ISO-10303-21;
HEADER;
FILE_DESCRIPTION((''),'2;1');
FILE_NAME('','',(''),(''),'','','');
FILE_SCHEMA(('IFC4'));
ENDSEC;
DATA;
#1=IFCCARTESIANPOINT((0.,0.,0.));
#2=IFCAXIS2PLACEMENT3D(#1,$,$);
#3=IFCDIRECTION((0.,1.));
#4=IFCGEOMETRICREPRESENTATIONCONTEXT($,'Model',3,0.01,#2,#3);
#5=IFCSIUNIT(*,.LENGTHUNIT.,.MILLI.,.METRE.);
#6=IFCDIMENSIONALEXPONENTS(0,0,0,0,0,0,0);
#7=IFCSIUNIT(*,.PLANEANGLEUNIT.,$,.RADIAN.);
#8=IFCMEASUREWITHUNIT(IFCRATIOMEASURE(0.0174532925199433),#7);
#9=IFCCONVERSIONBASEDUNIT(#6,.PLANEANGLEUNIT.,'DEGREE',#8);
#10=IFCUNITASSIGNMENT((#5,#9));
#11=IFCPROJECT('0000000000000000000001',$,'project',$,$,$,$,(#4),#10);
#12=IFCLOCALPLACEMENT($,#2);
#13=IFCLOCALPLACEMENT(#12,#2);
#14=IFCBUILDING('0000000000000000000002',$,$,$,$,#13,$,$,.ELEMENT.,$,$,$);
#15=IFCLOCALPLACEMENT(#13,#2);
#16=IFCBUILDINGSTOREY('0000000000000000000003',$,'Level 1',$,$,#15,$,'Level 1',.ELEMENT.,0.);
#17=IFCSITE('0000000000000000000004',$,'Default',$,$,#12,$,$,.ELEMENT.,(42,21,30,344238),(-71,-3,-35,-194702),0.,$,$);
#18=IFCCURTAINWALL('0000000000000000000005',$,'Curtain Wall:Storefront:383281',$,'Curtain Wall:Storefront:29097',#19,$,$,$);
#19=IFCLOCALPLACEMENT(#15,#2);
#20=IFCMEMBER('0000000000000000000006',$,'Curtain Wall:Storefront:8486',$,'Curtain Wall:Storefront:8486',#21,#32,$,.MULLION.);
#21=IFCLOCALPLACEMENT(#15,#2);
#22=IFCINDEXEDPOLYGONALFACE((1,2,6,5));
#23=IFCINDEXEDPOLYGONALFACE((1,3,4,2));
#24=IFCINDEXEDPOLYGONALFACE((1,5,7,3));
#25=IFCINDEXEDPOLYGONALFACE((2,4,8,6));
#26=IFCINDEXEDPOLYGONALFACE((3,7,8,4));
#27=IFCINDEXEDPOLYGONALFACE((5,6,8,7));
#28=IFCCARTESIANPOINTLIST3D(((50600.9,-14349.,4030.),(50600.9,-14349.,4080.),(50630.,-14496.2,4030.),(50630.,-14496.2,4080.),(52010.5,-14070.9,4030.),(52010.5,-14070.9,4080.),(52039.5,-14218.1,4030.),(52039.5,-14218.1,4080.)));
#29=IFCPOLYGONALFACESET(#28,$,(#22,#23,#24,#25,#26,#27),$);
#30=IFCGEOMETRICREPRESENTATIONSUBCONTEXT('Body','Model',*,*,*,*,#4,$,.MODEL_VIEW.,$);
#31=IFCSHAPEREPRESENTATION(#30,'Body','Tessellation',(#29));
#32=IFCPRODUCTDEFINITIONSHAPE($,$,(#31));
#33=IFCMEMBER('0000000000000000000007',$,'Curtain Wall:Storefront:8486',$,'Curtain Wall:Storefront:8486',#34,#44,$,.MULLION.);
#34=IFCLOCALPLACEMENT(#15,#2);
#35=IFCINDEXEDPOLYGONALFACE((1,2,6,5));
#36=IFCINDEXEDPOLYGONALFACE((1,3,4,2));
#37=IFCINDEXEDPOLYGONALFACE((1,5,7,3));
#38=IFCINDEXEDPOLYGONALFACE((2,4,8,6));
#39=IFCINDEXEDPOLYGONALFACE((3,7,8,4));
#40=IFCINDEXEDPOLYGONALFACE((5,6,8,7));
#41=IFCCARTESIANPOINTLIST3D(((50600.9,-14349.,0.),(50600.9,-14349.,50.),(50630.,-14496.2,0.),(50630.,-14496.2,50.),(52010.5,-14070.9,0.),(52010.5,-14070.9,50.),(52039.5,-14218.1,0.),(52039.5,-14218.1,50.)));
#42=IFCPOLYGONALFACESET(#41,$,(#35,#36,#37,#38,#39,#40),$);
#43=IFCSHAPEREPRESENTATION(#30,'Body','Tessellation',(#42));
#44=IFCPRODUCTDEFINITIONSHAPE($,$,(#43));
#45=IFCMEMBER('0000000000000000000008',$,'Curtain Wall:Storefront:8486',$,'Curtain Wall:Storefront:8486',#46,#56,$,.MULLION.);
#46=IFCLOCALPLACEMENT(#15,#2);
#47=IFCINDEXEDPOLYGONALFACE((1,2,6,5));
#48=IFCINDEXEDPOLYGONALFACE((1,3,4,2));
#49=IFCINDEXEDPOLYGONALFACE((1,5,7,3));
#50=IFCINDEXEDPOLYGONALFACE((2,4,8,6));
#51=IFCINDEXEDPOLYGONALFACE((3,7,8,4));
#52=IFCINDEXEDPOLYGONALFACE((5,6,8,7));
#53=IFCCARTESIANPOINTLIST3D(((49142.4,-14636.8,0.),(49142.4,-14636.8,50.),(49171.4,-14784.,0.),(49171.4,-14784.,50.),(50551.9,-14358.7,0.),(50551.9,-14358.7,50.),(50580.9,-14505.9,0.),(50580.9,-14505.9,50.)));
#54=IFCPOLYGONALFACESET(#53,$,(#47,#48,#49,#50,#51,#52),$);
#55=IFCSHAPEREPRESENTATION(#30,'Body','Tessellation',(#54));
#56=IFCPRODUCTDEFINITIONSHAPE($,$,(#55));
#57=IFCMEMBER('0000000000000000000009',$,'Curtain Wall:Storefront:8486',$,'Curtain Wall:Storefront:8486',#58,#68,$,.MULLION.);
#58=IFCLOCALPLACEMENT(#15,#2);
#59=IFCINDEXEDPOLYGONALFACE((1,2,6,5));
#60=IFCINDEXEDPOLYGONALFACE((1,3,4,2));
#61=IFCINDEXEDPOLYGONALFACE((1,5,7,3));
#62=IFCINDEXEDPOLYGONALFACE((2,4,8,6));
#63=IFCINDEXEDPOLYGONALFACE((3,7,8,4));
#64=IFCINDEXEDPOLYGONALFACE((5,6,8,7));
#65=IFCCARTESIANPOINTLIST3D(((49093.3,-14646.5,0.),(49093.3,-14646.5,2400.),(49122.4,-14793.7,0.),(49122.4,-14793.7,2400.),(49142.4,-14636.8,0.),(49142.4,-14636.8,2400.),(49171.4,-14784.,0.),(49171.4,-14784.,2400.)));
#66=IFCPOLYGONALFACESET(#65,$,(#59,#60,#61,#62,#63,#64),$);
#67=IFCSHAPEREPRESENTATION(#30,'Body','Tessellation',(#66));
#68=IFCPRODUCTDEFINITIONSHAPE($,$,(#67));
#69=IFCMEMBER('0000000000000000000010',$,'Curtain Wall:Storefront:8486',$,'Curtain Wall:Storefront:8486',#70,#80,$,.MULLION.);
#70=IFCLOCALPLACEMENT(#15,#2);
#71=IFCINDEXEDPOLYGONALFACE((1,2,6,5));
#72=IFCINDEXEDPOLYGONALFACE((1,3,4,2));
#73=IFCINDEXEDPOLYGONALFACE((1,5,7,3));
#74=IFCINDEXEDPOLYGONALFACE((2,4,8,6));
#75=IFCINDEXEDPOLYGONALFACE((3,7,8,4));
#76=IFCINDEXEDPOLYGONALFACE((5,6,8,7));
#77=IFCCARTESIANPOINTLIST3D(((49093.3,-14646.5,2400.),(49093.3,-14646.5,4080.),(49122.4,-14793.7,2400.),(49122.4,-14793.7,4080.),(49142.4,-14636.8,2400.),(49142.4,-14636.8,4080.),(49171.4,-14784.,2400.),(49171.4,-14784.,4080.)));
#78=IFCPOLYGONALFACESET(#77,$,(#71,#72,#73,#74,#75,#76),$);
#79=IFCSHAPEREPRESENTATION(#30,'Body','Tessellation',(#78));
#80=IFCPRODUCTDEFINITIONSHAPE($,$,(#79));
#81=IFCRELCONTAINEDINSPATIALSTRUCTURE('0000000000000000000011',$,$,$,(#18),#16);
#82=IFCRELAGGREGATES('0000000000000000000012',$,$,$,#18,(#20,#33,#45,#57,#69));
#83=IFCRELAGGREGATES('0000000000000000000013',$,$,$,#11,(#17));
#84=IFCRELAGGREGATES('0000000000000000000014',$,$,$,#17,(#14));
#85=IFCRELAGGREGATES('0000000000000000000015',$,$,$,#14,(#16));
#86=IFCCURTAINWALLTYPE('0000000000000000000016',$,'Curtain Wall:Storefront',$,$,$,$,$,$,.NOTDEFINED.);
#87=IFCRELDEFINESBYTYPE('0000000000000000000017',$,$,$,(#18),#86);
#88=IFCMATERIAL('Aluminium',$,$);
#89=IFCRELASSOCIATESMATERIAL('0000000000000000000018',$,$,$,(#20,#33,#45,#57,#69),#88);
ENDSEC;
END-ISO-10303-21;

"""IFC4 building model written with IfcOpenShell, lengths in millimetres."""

from ifc_helpers import new_model, entity, si_unit, converted_unit, direction, frame, frame_2d, origin, place, context, subcontext, project, spatial, rectangle, extrude, material, type_object, element, aggregate, save


model = new_model("IFC4")

# Units and contexts
model_context = context("Model", 3, precision=0.01, world=origin(), true_north=direction((0.0, 1.0)))
body_context = subcontext(model_context, "Body", "Model", "MODEL_VIEW")
ifc_project = project(units=[si_unit("LENGTHUNIT", "METRE", prefix="MILLI"), converted_unit("PLANEANGLEUNIT", "DEGREE", entity("IfcRatioMeasure", 0.0174532925199433), si_unit("PLANEANGLEUNIT", "RADIAN"), dimensions=[0, 0, 0, 0, 0, 0, 0])], contexts=[model_context])

# Site, building, storey
site_placement = place(None, origin())
site = spatial("IfcSite", under=ifc_project, at=site_placement, Name="Default", CompositionType="ELEMENT", RefLatitude=(42, 21, 30, 344238), RefLongitude=(-71, -3, -35, -194702), RefElevation=0.0)
building_placement = place(site_placement, origin())
building = spatial("IfcBuilding", under=site, at=building_placement, CompositionType="ELEMENT")
storey_placement = place(building_placement, origin())
storey = spatial("IfcBuildingStorey", under=building, at=storey_placement, Name="Level 1", LongName="Level 1", CompositionType="ELEMENT", Elevation=0.0)

# Curtain wall, members
curtain_wall_type = type_object("IfcCurtainWallType", Name="Curtain Wall:Storefront", PredefinedType="NOTDEFINED")
ifc_material = material(Name="Aluminium")
curtain_wall_1_placement = place(storey_placement, origin())
curtain_wall_1 = element("IfcCurtainWall", 1, at=curtain_wall_1_placement, inside=storey, type_object=curtain_wall_type, Name="Curtain Wall:Storefront:383281", ObjectType="Curtain Wall:Storefront:29097")
member_1_placement = place(curtain_wall_1_placement, origin())
member_1 = element("IfcMember", 2, at=member_1_placement, material=ifc_material, Name="Curtain Wall:Storefront:8486", ObjectType="Curtain Wall:Storefront:8486", PredefinedType="MULLION", context=body_context, shape_type="SweptSolid", body=[
    extrude(rectangle(XDim=50.0, YDim=150.0, at=frame_2d((0.0, 0.0), x_axis=(1.0, 0.0))), frame((50615.5, -14422.6, 4055.0), z_axis=(0.981087, 0.193568, 0.0), x_axis=(0.0, 0.0, -1.0)), (0.0, 0.0, 1.0), 1436.7),
])
member_2_placement = place(curtain_wall_1_placement, origin())
member_2 = element("IfcMember", 3, at=member_2_placement, material=ifc_material, Name="Curtain Wall:Storefront:8486", ObjectType="Curtain Wall:Storefront:8486", PredefinedType="MULLION", context=body_context, shape_type="SweptSolid", body=[
    extrude(rectangle(XDim=50.0, YDim=150.0, at=frame_2d((0.0, 0.0), x_axis=(1.0, 0.0))), frame((52025.0, -14144.5, 25.0), z_axis=(-0.981087, -0.193568, 0.0), x_axis=(0.0, 0.0, -1.0)), (0.0, 0.0, 1.0), 1436.7),
])
member_3_placement = place(curtain_wall_1_placement, origin())
member_3 = element("IfcMember", 4, at=member_3_placement, material=ifc_material, Name="Curtain Wall:Storefront:8486", ObjectType="Curtain Wall:Storefront:8486", PredefinedType="MULLION", context=body_context, shape_type="SweptSolid", body=[
    extrude(rectangle(XDim=50.0, YDim=150.0, at=frame_2d((0.0, 0.0), x_axis=(1.0, 0.0))), frame((50566.4, -14432.3, 25.0), z_axis=(-0.981087, -0.193568, 0.0), x_axis=(0.0, 0.0, -1.0)), (0.0, 0.0, 1.0), 1436.7),
])
member_4_placement = place(curtain_wall_1_placement, origin())
member_4 = element("IfcMember", 5, at=member_4_placement, material=ifc_material, Name="Curtain Wall:Storefront:8486", ObjectType="Curtain Wall:Storefront:8486", PredefinedType="MULLION", context=body_context, shape_type="SweptSolid", body=[
    extrude(rectangle(XDim=150.0, YDim=50.0, at=frame_2d((0.0, 0.0), x_axis=(1.0, 0.0))), frame((49132.4, -14715.2, 0.0), z_axis=(0.0, 0.0, 1.0), x_axis=(-0.193568, 0.981087, 0.0)), (0.0, 0.0, 1.0), 2400.0),
])
member_5_placement = place(curtain_wall_1_placement, origin())
member_5 = element("IfcMember", 6, at=member_5_placement, material=ifc_material, Name="Curtain Wall:Storefront:8486", ObjectType="Curtain Wall:Storefront:8486", PredefinedType="MULLION", context=body_context, shape_type="SweptSolid", body=[
    extrude(rectangle(XDim=150.0, YDim=50.0, at=frame_2d((0.0, 0.0), x_axis=(1.0, 0.0))), frame((49132.4, -14715.2, 2400.0), z_axis=(0.0, 0.0, 1.0), x_axis=(-0.193568, 0.981087, 0.0)), (0.0, 0.0, 1.0), 1680.0),
])
aggregate(curtain_wall_1, [member_1, member_2, member_3, member_4, member_5])

save(model, "model.ifc")
